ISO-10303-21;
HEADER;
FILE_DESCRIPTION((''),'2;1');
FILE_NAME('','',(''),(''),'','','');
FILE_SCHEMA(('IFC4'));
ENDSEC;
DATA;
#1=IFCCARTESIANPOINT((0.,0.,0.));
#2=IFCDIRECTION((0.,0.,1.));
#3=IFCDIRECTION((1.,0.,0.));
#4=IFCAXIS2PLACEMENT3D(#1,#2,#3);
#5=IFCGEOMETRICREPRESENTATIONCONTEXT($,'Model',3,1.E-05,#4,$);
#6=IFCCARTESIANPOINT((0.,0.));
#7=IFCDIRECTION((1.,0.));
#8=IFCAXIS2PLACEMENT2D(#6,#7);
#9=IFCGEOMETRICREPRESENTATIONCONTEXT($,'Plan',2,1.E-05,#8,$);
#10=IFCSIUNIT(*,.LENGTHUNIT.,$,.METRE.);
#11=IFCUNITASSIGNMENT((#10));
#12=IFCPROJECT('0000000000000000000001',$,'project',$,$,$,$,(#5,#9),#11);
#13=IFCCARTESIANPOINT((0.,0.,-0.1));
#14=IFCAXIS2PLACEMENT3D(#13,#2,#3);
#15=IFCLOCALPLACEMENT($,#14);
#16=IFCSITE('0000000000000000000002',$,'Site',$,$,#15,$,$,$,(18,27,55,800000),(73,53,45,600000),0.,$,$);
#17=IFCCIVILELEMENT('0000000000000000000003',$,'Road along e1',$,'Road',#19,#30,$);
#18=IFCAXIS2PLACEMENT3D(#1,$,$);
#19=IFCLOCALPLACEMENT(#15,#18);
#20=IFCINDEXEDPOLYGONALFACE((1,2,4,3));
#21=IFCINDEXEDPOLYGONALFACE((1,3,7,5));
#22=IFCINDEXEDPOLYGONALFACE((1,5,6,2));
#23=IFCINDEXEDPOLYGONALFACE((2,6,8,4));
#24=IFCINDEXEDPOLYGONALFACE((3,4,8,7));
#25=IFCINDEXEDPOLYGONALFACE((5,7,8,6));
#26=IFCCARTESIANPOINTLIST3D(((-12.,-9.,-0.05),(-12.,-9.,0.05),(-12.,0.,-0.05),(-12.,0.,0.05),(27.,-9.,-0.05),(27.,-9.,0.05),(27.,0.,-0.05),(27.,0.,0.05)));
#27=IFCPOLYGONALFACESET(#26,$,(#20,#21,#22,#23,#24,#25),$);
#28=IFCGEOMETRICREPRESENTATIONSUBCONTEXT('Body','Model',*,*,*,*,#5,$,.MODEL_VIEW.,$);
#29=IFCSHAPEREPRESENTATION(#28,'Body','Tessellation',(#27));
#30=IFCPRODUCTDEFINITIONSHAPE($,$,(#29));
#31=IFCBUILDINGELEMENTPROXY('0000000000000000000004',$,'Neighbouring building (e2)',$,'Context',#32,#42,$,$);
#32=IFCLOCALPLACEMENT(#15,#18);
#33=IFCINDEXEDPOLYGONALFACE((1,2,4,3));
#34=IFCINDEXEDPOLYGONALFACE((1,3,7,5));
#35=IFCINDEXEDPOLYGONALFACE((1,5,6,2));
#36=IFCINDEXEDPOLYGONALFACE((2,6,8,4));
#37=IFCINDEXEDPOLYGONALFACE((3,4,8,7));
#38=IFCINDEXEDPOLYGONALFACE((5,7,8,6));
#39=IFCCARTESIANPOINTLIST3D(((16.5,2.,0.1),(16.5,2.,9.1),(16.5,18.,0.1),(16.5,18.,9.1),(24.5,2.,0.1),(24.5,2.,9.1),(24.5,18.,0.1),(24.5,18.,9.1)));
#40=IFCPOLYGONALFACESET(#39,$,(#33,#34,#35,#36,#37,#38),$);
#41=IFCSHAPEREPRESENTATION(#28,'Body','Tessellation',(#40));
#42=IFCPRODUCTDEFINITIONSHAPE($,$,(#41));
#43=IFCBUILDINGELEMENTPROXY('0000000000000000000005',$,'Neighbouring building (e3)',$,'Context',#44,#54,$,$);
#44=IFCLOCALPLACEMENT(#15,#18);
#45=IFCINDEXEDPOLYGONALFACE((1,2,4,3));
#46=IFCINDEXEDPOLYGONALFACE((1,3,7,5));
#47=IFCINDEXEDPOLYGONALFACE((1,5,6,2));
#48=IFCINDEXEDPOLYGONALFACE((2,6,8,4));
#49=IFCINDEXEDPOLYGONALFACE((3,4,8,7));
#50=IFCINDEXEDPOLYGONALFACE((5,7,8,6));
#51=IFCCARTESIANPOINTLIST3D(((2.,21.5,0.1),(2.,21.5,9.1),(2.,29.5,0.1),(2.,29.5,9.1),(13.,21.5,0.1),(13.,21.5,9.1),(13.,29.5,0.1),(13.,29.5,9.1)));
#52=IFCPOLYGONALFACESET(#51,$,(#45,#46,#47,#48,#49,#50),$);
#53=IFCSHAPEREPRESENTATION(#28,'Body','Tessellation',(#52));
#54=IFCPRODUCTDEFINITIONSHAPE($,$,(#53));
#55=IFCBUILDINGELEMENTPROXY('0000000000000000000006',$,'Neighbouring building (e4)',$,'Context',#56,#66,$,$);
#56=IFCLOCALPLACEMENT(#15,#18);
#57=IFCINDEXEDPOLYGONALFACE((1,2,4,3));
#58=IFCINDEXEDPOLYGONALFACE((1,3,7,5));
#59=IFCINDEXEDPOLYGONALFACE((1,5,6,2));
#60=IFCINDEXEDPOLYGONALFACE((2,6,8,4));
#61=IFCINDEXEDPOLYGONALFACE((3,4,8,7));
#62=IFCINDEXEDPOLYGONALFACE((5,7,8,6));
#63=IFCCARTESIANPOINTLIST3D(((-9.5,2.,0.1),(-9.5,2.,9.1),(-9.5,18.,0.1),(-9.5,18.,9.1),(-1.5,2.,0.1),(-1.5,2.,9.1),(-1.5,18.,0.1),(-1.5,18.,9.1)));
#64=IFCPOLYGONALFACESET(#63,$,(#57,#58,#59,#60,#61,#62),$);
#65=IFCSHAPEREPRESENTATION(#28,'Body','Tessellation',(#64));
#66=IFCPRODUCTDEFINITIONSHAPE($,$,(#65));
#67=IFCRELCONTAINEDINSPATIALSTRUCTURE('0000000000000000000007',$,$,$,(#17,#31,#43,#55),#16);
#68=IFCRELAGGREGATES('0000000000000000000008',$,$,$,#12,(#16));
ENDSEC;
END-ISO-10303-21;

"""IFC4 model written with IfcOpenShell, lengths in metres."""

from ifc_helpers import new_model, si_unit, frame, origin_with_axes, origin_2d_with_axis, place, context, subcontext, project, spatial, line, indexed_curve, outline, extrude, element, save


model = new_model("IFC4")

# Units and contexts
model_context = context("Model", 3, precision=1e-05, world=origin_with_axes())
plan_context = context("Plan", 2, precision=1e-05, world=origin_2d_with_axis())
body_context = subcontext(model_context, "Body", "Model", "MODEL_VIEW")
ifc_project = project(units=[si_unit("LENGTHUNIT", "METRE")], contexts=[model_context, plan_context])

# Site
site_placement = place(None, frame((0.0, 0.0, -0.1), z_axis=(0.0, 0.0, 1.0), x_axis=(1.0, 0.0, 0.0)))
site = spatial("IfcSite", under=ifc_project, at=site_placement, Name="Site", RefLatitude=(18, 27, 55, 800000), RefLongitude=(73, 53, 45, 600000), RefElevation=0.0)

# Civil element
civil_element_placement = place(site_placement, frame((0.0, 0.0, -0.05), z_axis=(0.0, 0.0, 1.0), x_axis=(1.0, 0.0, 0.0)))
element("IfcCivilElement", 1, at=civil_element_placement, inside=site, Name="Road along e1", ObjectType="Road", context=body_context, shape_type="SweptSolid", body=[
    extrude(outline(indexed_curve([(-12.0, 0.0), (27.0, 0.0), (27.0, -9.0), (-12.0, -9.0)], segments=[line(1, 2, 3, 4, 1)])), origin_with_axes(), (0.0, 0.0, 1.0), 0.1),
])

# Building element proxies
proxy_1_placement = place(site_placement, frame((0.0, 0.0, 0.1), z_axis=(0.0, 0.0, 1.0), x_axis=(1.0, 0.0, 0.0)))
element("IfcBuildingElementProxy", 2, at=proxy_1_placement, inside=site, Name="Neighbouring building (e2)", ObjectType="Context", context=body_context, shape_type="SweptSolid", body=[
    extrude(outline(indexed_curve([(16.5, 2.0), (16.5, 18.0), (24.5, 18.0), (24.5, 2.0)], segments=[line(1, 2, 3, 4, 1)])), origin_with_axes(), (0.0, 0.0, 1.0), 9.0),
])
proxy_2_placement = place(site_placement, frame((0.0, 0.0, 0.1), z_axis=(0.0, 0.0, 1.0), x_axis=(1.0, 0.0, 0.0)))
element("IfcBuildingElementProxy", 3, at=proxy_2_placement, inside=site, Name="Neighbouring building (e3)", ObjectType="Context", context=body_context, shape_type="SweptSolid", body=[
    extrude(outline(indexed_curve([(13.0, 21.5), (2.0, 21.5), (2.0, 29.5), (13.0, 29.5)], segments=[line(1, 2, 3, 4, 1)])), origin_with_axes(), (0.0, 0.0, 1.0), 9.0),
])
proxy_3_placement = place(site_placement, frame((0.0, 0.0, 0.1), z_axis=(0.0, 0.0, 1.0), x_axis=(1.0, 0.0, 0.0)))
element("IfcBuildingElementProxy", 4, at=proxy_3_placement, inside=site, Name="Neighbouring building (e4)", ObjectType="Context", context=body_context, shape_type="SweptSolid", body=[
    extrude(outline(indexed_curve([(-1.5, 18.0), (-1.5, 2.0), (-9.5, 2.0), (-9.5, 18.0)], segments=[line(1, 2, 3, 4, 1)])), origin_with_axes(), (0.0, 0.0, 1.0), 9.0),
])

save(model, "model.ifc")
